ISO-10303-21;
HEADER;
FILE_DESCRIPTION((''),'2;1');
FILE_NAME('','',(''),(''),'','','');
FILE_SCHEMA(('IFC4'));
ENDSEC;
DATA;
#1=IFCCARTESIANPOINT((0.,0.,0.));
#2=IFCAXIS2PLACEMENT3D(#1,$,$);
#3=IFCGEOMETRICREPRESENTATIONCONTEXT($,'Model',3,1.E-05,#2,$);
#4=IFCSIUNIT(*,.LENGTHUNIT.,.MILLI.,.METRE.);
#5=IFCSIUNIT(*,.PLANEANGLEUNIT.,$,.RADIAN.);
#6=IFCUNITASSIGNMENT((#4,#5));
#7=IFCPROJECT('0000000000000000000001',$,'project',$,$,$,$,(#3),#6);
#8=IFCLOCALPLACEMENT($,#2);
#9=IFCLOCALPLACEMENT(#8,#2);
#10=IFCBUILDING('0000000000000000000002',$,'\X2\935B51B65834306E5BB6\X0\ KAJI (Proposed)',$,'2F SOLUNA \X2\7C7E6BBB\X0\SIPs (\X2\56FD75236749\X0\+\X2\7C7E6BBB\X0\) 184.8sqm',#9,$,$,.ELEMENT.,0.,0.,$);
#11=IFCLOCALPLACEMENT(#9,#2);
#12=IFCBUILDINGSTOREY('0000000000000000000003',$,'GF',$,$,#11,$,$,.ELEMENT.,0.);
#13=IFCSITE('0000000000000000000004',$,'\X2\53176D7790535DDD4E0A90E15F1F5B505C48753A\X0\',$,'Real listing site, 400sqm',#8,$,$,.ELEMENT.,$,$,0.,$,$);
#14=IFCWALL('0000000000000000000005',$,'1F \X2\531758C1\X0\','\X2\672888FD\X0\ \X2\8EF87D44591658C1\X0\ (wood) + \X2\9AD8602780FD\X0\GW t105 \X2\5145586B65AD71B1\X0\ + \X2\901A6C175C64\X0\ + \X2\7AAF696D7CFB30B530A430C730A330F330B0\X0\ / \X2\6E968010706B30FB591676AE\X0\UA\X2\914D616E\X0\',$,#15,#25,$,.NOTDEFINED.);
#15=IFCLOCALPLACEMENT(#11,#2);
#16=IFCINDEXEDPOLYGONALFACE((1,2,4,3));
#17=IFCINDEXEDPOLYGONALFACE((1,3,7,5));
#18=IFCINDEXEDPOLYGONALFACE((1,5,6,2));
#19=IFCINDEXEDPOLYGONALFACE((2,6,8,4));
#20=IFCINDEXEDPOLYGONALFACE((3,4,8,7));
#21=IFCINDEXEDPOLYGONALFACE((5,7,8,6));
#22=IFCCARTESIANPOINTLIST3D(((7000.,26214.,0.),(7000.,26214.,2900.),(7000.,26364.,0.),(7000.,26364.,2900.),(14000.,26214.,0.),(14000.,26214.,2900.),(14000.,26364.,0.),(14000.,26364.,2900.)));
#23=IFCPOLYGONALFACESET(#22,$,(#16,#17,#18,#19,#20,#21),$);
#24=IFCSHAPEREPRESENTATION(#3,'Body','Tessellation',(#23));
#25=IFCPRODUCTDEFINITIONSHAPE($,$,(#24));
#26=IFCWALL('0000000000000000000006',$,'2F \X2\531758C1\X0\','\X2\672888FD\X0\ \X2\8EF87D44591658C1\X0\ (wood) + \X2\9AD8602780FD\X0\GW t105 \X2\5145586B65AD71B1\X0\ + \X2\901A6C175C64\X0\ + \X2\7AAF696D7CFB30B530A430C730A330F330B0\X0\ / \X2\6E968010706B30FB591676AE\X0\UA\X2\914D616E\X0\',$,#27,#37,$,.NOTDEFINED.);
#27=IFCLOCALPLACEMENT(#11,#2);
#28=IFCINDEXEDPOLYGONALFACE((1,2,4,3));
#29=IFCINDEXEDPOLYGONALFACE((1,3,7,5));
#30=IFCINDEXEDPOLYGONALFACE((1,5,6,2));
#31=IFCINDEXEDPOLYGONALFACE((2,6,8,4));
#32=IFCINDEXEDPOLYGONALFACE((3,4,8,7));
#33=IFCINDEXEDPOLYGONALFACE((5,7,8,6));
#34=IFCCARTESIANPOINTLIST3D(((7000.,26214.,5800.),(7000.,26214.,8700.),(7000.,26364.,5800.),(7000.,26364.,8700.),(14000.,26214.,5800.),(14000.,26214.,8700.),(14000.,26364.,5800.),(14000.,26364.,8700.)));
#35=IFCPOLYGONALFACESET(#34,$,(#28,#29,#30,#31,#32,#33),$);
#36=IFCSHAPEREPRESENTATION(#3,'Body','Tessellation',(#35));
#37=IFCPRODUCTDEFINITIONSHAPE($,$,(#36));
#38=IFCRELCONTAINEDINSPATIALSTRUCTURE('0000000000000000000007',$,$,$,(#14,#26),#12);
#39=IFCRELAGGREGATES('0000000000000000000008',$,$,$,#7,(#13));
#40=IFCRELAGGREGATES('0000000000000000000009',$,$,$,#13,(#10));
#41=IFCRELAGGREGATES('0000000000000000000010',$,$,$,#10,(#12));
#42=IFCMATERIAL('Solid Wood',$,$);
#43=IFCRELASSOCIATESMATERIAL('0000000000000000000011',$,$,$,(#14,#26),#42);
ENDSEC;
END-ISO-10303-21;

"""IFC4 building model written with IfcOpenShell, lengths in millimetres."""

from ifc_helpers import new_model, si_unit, frame, frame_2d, origin, place, context, project, spatial, rectangle, extrude, material, element, save


model = new_model("IFC4")

# Units and contexts
model_context = context("Model", 3, precision=1e-05, world=origin())
ifc_project = project(units=[si_unit("LENGTHUNIT", "METRE", prefix="MILLI"), si_unit("PLANEANGLEUNIT", "RADIAN")], contexts=[model_context])

# Site, building, storey
site_placement = place(None, origin())
site = spatial("IfcSite", under=ifc_project, at=site_placement, Name="北海道川上郡弟子屈町", ObjectType="Real listing site, 400sqm", CompositionType="ELEMENT", RefElevation=0.0)
building_placement = place(site_placement, origin())
building = spatial("IfcBuilding", under=site, at=building_placement, Name="鍛冶場の家 KAJI (Proposed)", ObjectType="2F SOLUNA 籾殻SIPs (国産杉+籾殻) 184.8sqm", CompositionType="ELEMENT", ElevationOfRefHeight=0.0, ElevationOfTerrain=0.0)
storey_placement = place(building_placement, origin())
storey = spatial("IfcBuildingStorey", under=building, at=storey_placement, Name="GF", CompositionType="ELEMENT", Elevation=0.0)

# Shared definitions
ifc_material_1 = material(Name="Solid Wood")

# Wall
wall_1_placement = place(storey_placement, frame((3500.0, 13107.0, 0.0)))
element("IfcWall", 1, at=wall_1_placement, inside=storey, material=ifc_material_1, Name="1F 北壁", Description="木製 軸組外壁 (wood) + 高性能GW t105 充填断熱 + 通気層 + 窯業系サイディング / 準耐火・外皮UA配慮", PredefinedType="NOTDEFINED", context=model_context, shape_type="SweptSolid", body=[
    extrude(rectangle(XDim=7000.0, YDim=150.0, at=frame_2d((3500.0, 75.0))), frame((3500.0, 13107.0, 0.0)), (0.0, 0.0, 1.0), 2900.0),
])

# Wall
wall_2_placement = place(storey_placement, frame((3500.0, 13107.0, 2900.0)))
element("IfcWall", 2, at=wall_2_placement, inside=storey, material=ifc_material_1, Name="2F 北壁", Description="木製 軸組外壁 (wood) + 高性能GW t105 充填断熱 + 通気層 + 窯業系サイディング / 準耐火・外皮UA配慮", PredefinedType="NOTDEFINED", context=model_context, shape_type="SweptSolid", body=[
    extrude(rectangle(XDim=7000.0, YDim=150.0, at=frame_2d((3500.0, 75.0))), frame((3500.0, 13107.0, 2900.0)), (0.0, 0.0, 1.0), 2900.0),
])

save(model, "model.ifc")
